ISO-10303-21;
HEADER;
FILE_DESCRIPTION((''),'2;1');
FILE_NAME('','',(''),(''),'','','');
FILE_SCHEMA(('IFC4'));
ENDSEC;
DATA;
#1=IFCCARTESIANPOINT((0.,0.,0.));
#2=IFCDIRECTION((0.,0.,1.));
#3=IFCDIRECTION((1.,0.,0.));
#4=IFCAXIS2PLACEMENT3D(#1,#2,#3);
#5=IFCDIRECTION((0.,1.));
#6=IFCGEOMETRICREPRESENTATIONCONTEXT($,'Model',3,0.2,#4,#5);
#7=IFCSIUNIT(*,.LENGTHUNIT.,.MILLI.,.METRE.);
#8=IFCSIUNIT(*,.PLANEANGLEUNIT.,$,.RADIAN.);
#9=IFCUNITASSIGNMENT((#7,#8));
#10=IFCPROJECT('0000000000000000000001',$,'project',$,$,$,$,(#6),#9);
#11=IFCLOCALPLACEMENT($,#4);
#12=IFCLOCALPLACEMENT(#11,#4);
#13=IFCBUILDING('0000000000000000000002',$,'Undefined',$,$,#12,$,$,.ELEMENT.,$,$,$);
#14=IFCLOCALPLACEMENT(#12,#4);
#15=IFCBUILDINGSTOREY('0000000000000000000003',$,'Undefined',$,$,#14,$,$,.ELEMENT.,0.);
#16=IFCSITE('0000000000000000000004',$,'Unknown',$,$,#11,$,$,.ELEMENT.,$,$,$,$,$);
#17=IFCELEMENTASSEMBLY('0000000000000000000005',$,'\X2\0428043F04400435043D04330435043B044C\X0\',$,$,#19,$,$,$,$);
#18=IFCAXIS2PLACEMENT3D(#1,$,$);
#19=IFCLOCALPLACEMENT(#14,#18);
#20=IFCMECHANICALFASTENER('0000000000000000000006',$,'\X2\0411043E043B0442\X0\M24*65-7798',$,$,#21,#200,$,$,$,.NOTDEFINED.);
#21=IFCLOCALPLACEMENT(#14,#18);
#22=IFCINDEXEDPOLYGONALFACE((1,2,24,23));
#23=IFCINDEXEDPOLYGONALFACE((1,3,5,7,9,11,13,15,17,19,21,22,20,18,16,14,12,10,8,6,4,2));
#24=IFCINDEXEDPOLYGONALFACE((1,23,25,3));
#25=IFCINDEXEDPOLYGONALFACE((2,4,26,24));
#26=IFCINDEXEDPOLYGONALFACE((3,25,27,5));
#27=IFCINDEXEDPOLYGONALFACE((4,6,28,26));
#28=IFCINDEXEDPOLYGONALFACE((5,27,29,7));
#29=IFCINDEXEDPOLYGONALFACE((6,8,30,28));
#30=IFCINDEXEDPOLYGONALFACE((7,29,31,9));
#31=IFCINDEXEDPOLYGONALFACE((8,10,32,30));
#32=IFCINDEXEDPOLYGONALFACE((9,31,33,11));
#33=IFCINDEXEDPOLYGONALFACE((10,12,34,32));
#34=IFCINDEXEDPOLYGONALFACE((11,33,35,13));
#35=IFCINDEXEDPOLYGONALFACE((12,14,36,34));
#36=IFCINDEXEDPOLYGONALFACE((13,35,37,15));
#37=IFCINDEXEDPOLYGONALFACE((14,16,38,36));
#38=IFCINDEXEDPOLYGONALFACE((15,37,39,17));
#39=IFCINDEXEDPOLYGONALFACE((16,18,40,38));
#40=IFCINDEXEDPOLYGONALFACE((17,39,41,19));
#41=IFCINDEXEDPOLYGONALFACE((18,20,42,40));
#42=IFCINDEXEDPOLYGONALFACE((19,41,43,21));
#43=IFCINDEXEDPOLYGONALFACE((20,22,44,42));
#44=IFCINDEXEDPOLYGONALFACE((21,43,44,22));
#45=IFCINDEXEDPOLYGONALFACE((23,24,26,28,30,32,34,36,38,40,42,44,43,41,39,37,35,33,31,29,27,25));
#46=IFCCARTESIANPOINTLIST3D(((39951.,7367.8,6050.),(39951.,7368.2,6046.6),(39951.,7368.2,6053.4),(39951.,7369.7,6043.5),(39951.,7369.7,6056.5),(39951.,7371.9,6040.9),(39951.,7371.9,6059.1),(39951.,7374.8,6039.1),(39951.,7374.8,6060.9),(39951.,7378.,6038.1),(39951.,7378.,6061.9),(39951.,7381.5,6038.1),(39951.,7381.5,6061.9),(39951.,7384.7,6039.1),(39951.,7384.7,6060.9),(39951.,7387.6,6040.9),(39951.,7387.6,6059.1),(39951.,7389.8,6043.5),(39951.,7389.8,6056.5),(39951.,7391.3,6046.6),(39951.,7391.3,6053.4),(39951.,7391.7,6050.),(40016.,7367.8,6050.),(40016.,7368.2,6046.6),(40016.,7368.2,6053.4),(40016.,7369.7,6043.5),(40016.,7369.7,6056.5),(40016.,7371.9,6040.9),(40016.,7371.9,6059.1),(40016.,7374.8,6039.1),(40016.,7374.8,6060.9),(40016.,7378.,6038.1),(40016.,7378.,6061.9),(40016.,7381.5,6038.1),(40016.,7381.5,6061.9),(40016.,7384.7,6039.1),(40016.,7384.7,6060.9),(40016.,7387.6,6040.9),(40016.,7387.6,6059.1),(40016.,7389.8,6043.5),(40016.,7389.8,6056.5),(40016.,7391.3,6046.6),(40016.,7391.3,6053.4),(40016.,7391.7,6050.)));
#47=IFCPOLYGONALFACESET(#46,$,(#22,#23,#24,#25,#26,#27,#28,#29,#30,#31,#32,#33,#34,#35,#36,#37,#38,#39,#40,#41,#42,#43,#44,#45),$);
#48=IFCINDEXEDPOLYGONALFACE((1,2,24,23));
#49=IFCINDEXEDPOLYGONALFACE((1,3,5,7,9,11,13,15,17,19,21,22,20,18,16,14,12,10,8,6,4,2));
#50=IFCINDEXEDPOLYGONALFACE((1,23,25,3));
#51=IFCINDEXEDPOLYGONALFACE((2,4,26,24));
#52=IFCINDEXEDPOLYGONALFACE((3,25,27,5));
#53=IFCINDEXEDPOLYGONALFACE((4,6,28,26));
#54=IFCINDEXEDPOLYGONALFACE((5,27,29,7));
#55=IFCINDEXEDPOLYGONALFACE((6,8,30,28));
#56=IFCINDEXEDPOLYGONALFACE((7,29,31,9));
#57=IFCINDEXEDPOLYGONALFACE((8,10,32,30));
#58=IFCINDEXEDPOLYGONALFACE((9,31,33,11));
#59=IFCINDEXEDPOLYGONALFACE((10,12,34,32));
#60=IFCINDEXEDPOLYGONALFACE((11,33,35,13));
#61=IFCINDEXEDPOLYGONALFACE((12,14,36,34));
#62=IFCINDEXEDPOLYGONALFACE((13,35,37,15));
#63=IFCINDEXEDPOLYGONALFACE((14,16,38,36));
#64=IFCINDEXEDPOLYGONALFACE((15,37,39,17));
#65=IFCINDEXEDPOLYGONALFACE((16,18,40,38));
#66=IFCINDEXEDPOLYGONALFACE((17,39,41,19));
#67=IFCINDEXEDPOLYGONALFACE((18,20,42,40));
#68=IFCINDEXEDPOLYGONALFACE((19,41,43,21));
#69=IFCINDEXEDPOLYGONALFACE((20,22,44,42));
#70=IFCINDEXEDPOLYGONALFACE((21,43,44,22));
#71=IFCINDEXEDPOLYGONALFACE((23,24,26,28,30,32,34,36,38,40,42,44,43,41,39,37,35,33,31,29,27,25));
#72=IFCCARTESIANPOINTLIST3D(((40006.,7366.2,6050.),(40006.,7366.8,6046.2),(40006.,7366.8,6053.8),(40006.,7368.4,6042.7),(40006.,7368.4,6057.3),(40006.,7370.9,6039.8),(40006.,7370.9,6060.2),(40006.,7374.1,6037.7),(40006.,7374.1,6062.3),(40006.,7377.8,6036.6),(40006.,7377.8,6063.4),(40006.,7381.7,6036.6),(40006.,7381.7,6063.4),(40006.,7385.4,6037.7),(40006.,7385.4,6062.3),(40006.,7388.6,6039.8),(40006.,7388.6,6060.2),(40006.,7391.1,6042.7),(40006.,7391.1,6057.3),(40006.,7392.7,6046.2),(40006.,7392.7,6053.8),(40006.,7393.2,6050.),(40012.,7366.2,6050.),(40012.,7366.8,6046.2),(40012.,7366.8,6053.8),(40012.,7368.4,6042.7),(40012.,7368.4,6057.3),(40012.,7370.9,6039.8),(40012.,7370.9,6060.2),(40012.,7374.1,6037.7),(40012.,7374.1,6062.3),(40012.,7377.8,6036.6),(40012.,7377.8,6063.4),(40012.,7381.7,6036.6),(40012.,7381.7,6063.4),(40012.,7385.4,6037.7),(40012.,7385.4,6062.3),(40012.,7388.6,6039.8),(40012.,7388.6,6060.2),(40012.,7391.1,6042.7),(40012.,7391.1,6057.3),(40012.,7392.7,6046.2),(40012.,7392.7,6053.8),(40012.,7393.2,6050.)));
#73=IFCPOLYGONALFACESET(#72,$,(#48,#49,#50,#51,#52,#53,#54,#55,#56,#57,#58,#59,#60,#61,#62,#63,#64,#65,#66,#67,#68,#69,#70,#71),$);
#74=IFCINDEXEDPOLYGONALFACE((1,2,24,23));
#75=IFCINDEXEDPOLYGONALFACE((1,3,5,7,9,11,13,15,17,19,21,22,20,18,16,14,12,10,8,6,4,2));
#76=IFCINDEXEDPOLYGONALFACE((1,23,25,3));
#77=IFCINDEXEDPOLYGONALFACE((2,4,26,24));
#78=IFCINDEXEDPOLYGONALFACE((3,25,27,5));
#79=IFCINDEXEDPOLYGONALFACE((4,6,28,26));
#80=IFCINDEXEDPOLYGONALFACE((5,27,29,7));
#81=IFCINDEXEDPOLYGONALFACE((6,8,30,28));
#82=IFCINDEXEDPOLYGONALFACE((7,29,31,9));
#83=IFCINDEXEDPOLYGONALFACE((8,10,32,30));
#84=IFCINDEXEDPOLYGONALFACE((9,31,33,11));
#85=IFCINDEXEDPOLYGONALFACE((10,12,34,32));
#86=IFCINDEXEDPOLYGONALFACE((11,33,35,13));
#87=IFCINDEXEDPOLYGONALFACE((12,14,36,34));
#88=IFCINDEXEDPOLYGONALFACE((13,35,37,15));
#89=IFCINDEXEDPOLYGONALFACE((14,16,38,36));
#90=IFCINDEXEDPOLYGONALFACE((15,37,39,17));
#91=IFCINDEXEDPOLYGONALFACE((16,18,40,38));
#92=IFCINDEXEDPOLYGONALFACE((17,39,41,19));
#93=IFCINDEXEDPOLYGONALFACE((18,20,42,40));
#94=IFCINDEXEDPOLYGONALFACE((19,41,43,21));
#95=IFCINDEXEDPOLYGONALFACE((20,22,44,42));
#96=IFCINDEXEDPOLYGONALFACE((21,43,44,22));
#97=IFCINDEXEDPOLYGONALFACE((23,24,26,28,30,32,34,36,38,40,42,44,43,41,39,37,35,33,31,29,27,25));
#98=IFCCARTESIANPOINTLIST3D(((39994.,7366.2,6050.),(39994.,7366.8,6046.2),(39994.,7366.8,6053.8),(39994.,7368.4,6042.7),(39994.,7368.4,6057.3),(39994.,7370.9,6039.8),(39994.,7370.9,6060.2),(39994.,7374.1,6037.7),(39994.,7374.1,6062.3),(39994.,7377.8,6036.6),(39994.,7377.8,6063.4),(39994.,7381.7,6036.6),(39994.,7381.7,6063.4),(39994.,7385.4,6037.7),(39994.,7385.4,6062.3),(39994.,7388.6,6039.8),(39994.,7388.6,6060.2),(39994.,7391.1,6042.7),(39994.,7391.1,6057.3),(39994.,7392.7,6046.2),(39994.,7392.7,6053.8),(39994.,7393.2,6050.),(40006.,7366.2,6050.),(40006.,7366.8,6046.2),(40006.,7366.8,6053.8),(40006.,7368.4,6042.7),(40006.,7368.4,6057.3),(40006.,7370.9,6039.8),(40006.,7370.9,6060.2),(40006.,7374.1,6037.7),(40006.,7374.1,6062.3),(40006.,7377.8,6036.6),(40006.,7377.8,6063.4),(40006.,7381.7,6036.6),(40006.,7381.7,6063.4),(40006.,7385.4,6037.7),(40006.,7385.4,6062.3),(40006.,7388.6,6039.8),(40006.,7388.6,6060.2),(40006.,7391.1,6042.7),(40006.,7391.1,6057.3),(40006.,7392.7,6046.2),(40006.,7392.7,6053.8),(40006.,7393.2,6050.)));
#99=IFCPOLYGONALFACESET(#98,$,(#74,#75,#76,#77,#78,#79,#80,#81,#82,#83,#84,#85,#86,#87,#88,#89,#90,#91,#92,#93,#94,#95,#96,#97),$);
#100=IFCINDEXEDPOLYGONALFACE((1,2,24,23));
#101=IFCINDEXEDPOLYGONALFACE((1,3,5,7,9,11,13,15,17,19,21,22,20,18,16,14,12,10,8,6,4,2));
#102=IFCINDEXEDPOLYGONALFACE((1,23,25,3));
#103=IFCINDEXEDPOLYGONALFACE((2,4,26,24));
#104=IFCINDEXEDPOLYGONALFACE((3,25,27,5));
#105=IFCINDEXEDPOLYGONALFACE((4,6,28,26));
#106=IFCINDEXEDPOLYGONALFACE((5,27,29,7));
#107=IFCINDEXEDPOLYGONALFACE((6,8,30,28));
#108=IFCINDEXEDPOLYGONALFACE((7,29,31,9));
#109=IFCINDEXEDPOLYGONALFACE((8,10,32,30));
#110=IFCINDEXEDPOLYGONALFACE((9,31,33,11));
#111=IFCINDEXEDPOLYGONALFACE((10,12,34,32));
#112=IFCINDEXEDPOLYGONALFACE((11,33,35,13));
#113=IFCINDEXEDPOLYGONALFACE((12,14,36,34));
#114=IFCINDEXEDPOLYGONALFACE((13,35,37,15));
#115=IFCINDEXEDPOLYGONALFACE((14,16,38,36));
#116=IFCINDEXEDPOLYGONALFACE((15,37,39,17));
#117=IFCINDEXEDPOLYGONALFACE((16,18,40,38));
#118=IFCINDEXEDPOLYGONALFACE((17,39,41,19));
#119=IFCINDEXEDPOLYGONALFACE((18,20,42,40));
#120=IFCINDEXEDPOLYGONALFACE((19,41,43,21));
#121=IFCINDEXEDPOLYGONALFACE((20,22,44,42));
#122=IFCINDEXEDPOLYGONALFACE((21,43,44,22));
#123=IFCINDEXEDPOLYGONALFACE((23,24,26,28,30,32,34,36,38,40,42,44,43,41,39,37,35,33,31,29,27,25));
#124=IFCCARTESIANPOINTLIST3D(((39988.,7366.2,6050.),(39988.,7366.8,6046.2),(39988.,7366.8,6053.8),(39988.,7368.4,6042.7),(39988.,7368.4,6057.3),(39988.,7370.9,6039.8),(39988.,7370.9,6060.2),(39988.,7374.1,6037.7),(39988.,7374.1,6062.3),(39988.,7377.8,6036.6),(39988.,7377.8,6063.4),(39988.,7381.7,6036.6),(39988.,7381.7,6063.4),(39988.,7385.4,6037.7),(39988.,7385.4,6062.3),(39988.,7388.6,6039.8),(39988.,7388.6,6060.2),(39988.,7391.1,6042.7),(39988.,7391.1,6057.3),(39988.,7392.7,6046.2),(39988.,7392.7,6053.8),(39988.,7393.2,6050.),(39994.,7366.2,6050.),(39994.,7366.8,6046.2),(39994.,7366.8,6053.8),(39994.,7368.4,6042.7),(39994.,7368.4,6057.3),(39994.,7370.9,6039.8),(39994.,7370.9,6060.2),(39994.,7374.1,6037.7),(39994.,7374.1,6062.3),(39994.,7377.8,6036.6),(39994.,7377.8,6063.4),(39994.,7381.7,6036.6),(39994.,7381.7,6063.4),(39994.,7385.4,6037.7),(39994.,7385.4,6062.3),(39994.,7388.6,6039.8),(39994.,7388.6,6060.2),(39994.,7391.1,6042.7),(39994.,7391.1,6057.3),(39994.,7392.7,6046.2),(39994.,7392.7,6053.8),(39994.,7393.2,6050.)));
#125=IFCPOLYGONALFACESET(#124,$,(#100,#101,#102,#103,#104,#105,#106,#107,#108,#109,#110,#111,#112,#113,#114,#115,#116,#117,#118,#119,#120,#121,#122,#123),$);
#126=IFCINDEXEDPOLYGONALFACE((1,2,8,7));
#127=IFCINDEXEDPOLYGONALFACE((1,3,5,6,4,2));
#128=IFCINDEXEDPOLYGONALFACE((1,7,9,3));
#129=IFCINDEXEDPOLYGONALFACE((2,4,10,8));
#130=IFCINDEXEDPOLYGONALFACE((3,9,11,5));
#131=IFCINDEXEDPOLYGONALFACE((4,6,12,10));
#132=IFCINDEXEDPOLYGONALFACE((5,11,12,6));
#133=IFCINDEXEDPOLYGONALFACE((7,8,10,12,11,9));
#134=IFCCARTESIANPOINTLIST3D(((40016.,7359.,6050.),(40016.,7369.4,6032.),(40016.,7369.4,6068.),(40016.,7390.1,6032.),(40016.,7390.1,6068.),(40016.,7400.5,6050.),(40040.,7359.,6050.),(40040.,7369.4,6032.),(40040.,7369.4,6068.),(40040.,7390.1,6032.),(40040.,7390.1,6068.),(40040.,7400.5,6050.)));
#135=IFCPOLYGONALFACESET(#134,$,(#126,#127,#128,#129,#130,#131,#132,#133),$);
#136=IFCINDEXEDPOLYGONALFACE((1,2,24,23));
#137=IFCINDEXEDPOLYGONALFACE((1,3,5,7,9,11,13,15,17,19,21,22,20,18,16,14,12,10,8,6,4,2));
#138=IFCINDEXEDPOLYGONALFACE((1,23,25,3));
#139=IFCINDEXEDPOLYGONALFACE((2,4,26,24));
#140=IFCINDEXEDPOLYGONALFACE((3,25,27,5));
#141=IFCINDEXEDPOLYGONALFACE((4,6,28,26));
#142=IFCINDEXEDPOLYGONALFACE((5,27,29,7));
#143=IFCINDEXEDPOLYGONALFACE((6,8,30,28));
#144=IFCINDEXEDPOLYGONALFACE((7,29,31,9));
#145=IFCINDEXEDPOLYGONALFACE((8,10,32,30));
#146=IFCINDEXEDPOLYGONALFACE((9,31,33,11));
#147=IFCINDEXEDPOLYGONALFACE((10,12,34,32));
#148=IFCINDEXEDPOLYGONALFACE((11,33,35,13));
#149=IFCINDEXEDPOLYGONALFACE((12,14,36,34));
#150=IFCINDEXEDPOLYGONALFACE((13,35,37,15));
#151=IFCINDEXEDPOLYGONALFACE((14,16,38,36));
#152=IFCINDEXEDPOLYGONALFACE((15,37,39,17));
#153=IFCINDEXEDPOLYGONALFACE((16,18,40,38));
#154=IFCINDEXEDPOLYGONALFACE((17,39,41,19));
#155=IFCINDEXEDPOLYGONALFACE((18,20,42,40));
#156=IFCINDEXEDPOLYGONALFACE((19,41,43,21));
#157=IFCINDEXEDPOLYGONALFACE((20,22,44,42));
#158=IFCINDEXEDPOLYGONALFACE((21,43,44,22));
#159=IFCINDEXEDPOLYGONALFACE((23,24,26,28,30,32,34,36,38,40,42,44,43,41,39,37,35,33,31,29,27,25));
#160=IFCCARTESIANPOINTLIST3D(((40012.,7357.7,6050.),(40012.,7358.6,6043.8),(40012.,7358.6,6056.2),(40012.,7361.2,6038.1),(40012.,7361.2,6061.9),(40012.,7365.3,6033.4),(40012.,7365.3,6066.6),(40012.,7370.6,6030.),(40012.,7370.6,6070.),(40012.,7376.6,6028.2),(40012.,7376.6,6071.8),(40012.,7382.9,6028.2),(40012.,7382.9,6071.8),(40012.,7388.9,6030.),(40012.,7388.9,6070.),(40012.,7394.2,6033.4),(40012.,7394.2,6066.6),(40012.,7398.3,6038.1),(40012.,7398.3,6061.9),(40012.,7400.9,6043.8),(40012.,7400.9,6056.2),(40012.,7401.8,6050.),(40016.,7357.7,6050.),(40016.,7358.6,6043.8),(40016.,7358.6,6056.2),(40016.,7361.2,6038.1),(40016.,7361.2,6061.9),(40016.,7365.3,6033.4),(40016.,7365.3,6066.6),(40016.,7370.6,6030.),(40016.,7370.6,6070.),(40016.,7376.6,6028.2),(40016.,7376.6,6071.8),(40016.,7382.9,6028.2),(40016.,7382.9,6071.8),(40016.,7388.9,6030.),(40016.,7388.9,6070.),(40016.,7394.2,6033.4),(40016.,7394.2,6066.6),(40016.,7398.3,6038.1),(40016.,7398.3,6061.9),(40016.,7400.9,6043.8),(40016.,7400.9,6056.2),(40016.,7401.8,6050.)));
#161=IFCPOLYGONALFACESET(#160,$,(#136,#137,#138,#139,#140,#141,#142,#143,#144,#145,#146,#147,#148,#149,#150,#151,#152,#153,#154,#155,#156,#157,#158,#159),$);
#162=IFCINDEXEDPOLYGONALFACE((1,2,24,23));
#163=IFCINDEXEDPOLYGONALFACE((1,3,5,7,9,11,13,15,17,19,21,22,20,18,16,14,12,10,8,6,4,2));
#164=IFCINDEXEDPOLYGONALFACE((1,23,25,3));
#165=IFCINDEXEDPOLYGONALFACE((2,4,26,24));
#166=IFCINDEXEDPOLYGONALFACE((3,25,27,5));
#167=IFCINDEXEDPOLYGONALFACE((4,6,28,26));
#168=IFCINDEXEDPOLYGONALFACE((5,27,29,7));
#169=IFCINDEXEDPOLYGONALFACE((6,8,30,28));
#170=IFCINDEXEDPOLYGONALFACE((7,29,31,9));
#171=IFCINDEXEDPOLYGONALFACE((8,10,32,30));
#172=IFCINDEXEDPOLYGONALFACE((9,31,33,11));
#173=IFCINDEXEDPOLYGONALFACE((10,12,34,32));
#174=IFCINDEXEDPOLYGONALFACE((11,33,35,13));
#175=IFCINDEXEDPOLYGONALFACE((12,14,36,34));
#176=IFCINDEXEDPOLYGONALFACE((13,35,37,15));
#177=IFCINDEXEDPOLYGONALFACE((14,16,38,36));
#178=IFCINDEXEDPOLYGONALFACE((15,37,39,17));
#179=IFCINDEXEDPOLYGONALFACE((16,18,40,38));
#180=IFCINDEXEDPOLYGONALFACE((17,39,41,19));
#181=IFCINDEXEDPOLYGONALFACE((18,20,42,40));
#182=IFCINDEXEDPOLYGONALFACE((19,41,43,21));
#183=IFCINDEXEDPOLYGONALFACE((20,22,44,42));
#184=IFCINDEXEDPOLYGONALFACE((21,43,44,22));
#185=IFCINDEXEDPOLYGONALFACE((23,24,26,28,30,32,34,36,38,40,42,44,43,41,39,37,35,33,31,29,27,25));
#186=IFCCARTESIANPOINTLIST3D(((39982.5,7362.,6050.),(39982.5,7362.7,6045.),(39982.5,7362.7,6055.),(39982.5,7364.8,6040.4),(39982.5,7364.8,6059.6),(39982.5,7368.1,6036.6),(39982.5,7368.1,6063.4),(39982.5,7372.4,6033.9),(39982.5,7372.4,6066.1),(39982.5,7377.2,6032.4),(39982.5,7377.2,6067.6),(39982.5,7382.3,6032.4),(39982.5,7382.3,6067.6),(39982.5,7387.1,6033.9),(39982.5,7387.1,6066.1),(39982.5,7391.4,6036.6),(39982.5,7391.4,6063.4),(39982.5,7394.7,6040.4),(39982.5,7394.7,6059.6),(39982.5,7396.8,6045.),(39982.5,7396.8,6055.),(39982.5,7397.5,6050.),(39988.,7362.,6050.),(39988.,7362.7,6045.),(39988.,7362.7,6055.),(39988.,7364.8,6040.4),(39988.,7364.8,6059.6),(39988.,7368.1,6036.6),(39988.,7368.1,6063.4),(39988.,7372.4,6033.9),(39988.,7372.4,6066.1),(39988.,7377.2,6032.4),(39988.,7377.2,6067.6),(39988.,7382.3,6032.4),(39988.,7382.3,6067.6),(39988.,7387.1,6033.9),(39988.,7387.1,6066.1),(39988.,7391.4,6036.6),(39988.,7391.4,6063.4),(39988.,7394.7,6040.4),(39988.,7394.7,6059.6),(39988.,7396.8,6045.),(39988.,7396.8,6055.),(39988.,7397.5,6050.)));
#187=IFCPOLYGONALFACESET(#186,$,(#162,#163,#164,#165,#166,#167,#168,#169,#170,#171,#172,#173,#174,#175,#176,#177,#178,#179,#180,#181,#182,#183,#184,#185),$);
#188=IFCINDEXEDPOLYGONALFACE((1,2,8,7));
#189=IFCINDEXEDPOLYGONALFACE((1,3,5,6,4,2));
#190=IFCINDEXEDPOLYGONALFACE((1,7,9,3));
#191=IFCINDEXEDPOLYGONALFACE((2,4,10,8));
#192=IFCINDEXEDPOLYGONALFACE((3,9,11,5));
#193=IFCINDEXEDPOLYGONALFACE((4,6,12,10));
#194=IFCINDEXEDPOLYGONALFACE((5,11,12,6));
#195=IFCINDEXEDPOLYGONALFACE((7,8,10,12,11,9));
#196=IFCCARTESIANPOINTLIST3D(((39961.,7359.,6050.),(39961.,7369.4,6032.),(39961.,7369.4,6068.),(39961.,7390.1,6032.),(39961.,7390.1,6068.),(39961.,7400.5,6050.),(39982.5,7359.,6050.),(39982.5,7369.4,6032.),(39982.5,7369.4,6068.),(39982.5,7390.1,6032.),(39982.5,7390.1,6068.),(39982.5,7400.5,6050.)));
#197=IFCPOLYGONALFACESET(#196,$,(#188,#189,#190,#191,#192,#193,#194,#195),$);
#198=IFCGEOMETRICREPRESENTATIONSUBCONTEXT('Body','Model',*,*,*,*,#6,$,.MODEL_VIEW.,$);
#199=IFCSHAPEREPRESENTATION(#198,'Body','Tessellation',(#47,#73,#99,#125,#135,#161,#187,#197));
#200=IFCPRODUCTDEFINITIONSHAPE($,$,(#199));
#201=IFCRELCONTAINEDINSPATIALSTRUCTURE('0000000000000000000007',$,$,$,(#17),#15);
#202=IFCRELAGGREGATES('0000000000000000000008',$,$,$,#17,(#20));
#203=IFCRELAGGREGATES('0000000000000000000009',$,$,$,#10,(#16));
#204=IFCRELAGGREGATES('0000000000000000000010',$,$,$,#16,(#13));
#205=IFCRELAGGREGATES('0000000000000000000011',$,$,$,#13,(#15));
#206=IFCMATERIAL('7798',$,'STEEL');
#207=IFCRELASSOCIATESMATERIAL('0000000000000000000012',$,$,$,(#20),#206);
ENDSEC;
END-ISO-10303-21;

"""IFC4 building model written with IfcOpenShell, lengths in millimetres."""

from ifc_helpers import new_model, si_unit, direction, frame, origin_with_axes, place, context, subcontext, project, spatial, line, arc, indexed_curve, outline, extrude, source, transform, mapped, material, element, aggregate, save


model = new_model("IFC4")

# Units and contexts
model_context = context("Model", 3, precision=0.2, world=origin_with_axes(), true_north=direction((0.0, 1.0)))
body_context = subcontext(model_context, "Body", "Model", "MODEL_VIEW")
ifc_project = project(units=[si_unit("LENGTHUNIT", "METRE", prefix="MILLI"), si_unit("PLANEANGLEUNIT", "RADIAN")], contexts=[model_context])

# Site, building, storey
site_placement = place(None, origin_with_axes())
site = spatial("IfcSite", under=ifc_project, at=site_placement, Name="Unknown", CompositionType="ELEMENT")
building_placement = place(site_placement, origin_with_axes())
building = spatial("IfcBuilding", under=site, at=building_placement, Name="Undefined", CompositionType="ELEMENT")
storey_placement = place(building_placement, origin_with_axes())
storey = spatial("IfcBuildingStorey", under=building, at=storey_placement, Name="Undefined", CompositionType="ELEMENT", Elevation=0.0)

# Shared definitions
ifc_material_1 = material(Name="7798", Category="STEEL")

# Element assembly, mechanical fastener
assembly_1_placement = place(storey_placement, frame((39949.0, 5673.0, 6045.0), z_axis=(0.0, 0.0, 1.0), x_axis=(0.0, 1.0, 0.0)))
assembly_1 = element("IfcElementAssembly", 1, at=assembly_1_placement, inside=storey, Name="Шпренгель")
shared_shape_1 = source(origin_with_axes(), body_context, "Body", "SweptSolid", [
    extrude(outline(indexed_curve([(12.0, 0.0), (0.0, 12.0), (-12.0, 0.0), (0.0, -12.0)], segments=[arc(1, 2, 3), arc(3, 4, 1)])), frame((0.0, 0.0, 16.0), z_axis=(0.0, 0.0, -1.0), x_axis=(0.0, 1.0, 0.0)), (0.0, 0.0, 1.0), 65.0),
    extrude(outline(indexed_curve([(13.5, 0.0), (0.0, 13.5), (-13.5, 0.0), (0.0, -13.5)], segments=[arc(1, 2, 3), arc(3, 4, 1)])), frame((0.0, 0.0, 12.0), z_axis=(0.0, 0.0, -1.0), x_axis=(0.0, 1.0, 0.0)), (0.0, 0.0, 1.0), 6.0),
    extrude(outline(indexed_curve([(13.5, 0.0), (0.0, 13.5), (-13.5, 0.0), (0.0, -13.5)], segments=[arc(1, 2, 3), arc(3, 4, 1)])), frame((0.0, 0.0, 6.0), z_axis=(0.0, 0.0, -1.0), x_axis=(0.0, 1.0, 0.0)), (0.0, 0.0, 1.0), 12.0),
    extrude(outline(indexed_curve([(13.5, 0.0), (0.0, 13.5), (-13.5, 0.0), (0.0, -13.5)], segments=[arc(1, 2, 3), arc(3, 4, 1)])), frame((0.0, 0.0, -6.0), z_axis=(0.0, 0.0, -1.0), x_axis=(0.0, 1.0, 0.0)), (0.0, 0.0, 1.0), 6.0),
    extrude(outline(indexed_curve([(20.8, 0.0), (10.4, 18.0), (-10.4, 18.0), (-20.8, 0.0), (-10.4, -18.0), (10.4, -18.0)], segments=[line(1, 2, 3, 4, 5, 6, 1)])), frame((0.0, 0.0, 40.0), z_axis=(0.0, 0.0, -1.0), x_axis=(0.0, 1.0, 0.0)), (0.0, 0.0, 1.0), 24.0),
    extrude(outline(indexed_curve([(22.0, 0.0), (0.0, 22.0), (-22.0, 0.0), (0.0, -22.0)], segments=[arc(1, 2, 3), arc(3, 4, 1)])), frame((0.0, 0.0, 16.0), z_axis=(0.0, 0.0, -1.0), x_axis=(0.0, 1.0, 0.0)), (0.0, 0.0, 1.0), 4.0),
    extrude(outline(indexed_curve([(17.8, 0.0), (0.0, 17.8), (-17.8, 0.0), (0.0, -17.8)], segments=[arc(1, 2, 3), arc(3, 4, 1)])), frame((0.0, 0.0, -12.0), z_axis=(0.0, 0.0, -1.0), x_axis=(0.0, 1.0, 0.0)), (0.0, 0.0, 1.0), 5.5),
    extrude(outline(indexed_curve([(20.8, 0.0), (10.4, 18.0), (-10.4, 18.0), (-20.8, 0.0), (-10.4, -18.0), (10.4, -18.0)], segments=[line(1, 2, 3, 4, 5, 6, 1)])), frame((0.0, 0.0, -17.5), z_axis=(0.0, 0.0, -1.0), x_axis=(0.0, 1.0, 0.0)), (0.0, 0.0, 1.0), 21.5),
])
mechanical_fastener_1_placement = place(assembly_1_placement, frame((1706.8, -51.0, 5.0), z_axis=(0.0, -1.0, 0.0), x_axis=(0.0, 0.0, 1.0)))
mechanical_fastener_1 = element("IfcMechanicalFastener", 2, at=mechanical_fastener_1_placement, material=ifc_material_1, Name="БолтM24*65-7798", PredefinedType="NOTDEFINED", context=body_context, shape_type="MappedRepresentation", body=[
    mapped(shared_shape_1, transform((0.0, 0.0, 0.0))),
])
aggregate(assembly_1, [mechanical_fastener_1])

save(model, "model.ifc")
